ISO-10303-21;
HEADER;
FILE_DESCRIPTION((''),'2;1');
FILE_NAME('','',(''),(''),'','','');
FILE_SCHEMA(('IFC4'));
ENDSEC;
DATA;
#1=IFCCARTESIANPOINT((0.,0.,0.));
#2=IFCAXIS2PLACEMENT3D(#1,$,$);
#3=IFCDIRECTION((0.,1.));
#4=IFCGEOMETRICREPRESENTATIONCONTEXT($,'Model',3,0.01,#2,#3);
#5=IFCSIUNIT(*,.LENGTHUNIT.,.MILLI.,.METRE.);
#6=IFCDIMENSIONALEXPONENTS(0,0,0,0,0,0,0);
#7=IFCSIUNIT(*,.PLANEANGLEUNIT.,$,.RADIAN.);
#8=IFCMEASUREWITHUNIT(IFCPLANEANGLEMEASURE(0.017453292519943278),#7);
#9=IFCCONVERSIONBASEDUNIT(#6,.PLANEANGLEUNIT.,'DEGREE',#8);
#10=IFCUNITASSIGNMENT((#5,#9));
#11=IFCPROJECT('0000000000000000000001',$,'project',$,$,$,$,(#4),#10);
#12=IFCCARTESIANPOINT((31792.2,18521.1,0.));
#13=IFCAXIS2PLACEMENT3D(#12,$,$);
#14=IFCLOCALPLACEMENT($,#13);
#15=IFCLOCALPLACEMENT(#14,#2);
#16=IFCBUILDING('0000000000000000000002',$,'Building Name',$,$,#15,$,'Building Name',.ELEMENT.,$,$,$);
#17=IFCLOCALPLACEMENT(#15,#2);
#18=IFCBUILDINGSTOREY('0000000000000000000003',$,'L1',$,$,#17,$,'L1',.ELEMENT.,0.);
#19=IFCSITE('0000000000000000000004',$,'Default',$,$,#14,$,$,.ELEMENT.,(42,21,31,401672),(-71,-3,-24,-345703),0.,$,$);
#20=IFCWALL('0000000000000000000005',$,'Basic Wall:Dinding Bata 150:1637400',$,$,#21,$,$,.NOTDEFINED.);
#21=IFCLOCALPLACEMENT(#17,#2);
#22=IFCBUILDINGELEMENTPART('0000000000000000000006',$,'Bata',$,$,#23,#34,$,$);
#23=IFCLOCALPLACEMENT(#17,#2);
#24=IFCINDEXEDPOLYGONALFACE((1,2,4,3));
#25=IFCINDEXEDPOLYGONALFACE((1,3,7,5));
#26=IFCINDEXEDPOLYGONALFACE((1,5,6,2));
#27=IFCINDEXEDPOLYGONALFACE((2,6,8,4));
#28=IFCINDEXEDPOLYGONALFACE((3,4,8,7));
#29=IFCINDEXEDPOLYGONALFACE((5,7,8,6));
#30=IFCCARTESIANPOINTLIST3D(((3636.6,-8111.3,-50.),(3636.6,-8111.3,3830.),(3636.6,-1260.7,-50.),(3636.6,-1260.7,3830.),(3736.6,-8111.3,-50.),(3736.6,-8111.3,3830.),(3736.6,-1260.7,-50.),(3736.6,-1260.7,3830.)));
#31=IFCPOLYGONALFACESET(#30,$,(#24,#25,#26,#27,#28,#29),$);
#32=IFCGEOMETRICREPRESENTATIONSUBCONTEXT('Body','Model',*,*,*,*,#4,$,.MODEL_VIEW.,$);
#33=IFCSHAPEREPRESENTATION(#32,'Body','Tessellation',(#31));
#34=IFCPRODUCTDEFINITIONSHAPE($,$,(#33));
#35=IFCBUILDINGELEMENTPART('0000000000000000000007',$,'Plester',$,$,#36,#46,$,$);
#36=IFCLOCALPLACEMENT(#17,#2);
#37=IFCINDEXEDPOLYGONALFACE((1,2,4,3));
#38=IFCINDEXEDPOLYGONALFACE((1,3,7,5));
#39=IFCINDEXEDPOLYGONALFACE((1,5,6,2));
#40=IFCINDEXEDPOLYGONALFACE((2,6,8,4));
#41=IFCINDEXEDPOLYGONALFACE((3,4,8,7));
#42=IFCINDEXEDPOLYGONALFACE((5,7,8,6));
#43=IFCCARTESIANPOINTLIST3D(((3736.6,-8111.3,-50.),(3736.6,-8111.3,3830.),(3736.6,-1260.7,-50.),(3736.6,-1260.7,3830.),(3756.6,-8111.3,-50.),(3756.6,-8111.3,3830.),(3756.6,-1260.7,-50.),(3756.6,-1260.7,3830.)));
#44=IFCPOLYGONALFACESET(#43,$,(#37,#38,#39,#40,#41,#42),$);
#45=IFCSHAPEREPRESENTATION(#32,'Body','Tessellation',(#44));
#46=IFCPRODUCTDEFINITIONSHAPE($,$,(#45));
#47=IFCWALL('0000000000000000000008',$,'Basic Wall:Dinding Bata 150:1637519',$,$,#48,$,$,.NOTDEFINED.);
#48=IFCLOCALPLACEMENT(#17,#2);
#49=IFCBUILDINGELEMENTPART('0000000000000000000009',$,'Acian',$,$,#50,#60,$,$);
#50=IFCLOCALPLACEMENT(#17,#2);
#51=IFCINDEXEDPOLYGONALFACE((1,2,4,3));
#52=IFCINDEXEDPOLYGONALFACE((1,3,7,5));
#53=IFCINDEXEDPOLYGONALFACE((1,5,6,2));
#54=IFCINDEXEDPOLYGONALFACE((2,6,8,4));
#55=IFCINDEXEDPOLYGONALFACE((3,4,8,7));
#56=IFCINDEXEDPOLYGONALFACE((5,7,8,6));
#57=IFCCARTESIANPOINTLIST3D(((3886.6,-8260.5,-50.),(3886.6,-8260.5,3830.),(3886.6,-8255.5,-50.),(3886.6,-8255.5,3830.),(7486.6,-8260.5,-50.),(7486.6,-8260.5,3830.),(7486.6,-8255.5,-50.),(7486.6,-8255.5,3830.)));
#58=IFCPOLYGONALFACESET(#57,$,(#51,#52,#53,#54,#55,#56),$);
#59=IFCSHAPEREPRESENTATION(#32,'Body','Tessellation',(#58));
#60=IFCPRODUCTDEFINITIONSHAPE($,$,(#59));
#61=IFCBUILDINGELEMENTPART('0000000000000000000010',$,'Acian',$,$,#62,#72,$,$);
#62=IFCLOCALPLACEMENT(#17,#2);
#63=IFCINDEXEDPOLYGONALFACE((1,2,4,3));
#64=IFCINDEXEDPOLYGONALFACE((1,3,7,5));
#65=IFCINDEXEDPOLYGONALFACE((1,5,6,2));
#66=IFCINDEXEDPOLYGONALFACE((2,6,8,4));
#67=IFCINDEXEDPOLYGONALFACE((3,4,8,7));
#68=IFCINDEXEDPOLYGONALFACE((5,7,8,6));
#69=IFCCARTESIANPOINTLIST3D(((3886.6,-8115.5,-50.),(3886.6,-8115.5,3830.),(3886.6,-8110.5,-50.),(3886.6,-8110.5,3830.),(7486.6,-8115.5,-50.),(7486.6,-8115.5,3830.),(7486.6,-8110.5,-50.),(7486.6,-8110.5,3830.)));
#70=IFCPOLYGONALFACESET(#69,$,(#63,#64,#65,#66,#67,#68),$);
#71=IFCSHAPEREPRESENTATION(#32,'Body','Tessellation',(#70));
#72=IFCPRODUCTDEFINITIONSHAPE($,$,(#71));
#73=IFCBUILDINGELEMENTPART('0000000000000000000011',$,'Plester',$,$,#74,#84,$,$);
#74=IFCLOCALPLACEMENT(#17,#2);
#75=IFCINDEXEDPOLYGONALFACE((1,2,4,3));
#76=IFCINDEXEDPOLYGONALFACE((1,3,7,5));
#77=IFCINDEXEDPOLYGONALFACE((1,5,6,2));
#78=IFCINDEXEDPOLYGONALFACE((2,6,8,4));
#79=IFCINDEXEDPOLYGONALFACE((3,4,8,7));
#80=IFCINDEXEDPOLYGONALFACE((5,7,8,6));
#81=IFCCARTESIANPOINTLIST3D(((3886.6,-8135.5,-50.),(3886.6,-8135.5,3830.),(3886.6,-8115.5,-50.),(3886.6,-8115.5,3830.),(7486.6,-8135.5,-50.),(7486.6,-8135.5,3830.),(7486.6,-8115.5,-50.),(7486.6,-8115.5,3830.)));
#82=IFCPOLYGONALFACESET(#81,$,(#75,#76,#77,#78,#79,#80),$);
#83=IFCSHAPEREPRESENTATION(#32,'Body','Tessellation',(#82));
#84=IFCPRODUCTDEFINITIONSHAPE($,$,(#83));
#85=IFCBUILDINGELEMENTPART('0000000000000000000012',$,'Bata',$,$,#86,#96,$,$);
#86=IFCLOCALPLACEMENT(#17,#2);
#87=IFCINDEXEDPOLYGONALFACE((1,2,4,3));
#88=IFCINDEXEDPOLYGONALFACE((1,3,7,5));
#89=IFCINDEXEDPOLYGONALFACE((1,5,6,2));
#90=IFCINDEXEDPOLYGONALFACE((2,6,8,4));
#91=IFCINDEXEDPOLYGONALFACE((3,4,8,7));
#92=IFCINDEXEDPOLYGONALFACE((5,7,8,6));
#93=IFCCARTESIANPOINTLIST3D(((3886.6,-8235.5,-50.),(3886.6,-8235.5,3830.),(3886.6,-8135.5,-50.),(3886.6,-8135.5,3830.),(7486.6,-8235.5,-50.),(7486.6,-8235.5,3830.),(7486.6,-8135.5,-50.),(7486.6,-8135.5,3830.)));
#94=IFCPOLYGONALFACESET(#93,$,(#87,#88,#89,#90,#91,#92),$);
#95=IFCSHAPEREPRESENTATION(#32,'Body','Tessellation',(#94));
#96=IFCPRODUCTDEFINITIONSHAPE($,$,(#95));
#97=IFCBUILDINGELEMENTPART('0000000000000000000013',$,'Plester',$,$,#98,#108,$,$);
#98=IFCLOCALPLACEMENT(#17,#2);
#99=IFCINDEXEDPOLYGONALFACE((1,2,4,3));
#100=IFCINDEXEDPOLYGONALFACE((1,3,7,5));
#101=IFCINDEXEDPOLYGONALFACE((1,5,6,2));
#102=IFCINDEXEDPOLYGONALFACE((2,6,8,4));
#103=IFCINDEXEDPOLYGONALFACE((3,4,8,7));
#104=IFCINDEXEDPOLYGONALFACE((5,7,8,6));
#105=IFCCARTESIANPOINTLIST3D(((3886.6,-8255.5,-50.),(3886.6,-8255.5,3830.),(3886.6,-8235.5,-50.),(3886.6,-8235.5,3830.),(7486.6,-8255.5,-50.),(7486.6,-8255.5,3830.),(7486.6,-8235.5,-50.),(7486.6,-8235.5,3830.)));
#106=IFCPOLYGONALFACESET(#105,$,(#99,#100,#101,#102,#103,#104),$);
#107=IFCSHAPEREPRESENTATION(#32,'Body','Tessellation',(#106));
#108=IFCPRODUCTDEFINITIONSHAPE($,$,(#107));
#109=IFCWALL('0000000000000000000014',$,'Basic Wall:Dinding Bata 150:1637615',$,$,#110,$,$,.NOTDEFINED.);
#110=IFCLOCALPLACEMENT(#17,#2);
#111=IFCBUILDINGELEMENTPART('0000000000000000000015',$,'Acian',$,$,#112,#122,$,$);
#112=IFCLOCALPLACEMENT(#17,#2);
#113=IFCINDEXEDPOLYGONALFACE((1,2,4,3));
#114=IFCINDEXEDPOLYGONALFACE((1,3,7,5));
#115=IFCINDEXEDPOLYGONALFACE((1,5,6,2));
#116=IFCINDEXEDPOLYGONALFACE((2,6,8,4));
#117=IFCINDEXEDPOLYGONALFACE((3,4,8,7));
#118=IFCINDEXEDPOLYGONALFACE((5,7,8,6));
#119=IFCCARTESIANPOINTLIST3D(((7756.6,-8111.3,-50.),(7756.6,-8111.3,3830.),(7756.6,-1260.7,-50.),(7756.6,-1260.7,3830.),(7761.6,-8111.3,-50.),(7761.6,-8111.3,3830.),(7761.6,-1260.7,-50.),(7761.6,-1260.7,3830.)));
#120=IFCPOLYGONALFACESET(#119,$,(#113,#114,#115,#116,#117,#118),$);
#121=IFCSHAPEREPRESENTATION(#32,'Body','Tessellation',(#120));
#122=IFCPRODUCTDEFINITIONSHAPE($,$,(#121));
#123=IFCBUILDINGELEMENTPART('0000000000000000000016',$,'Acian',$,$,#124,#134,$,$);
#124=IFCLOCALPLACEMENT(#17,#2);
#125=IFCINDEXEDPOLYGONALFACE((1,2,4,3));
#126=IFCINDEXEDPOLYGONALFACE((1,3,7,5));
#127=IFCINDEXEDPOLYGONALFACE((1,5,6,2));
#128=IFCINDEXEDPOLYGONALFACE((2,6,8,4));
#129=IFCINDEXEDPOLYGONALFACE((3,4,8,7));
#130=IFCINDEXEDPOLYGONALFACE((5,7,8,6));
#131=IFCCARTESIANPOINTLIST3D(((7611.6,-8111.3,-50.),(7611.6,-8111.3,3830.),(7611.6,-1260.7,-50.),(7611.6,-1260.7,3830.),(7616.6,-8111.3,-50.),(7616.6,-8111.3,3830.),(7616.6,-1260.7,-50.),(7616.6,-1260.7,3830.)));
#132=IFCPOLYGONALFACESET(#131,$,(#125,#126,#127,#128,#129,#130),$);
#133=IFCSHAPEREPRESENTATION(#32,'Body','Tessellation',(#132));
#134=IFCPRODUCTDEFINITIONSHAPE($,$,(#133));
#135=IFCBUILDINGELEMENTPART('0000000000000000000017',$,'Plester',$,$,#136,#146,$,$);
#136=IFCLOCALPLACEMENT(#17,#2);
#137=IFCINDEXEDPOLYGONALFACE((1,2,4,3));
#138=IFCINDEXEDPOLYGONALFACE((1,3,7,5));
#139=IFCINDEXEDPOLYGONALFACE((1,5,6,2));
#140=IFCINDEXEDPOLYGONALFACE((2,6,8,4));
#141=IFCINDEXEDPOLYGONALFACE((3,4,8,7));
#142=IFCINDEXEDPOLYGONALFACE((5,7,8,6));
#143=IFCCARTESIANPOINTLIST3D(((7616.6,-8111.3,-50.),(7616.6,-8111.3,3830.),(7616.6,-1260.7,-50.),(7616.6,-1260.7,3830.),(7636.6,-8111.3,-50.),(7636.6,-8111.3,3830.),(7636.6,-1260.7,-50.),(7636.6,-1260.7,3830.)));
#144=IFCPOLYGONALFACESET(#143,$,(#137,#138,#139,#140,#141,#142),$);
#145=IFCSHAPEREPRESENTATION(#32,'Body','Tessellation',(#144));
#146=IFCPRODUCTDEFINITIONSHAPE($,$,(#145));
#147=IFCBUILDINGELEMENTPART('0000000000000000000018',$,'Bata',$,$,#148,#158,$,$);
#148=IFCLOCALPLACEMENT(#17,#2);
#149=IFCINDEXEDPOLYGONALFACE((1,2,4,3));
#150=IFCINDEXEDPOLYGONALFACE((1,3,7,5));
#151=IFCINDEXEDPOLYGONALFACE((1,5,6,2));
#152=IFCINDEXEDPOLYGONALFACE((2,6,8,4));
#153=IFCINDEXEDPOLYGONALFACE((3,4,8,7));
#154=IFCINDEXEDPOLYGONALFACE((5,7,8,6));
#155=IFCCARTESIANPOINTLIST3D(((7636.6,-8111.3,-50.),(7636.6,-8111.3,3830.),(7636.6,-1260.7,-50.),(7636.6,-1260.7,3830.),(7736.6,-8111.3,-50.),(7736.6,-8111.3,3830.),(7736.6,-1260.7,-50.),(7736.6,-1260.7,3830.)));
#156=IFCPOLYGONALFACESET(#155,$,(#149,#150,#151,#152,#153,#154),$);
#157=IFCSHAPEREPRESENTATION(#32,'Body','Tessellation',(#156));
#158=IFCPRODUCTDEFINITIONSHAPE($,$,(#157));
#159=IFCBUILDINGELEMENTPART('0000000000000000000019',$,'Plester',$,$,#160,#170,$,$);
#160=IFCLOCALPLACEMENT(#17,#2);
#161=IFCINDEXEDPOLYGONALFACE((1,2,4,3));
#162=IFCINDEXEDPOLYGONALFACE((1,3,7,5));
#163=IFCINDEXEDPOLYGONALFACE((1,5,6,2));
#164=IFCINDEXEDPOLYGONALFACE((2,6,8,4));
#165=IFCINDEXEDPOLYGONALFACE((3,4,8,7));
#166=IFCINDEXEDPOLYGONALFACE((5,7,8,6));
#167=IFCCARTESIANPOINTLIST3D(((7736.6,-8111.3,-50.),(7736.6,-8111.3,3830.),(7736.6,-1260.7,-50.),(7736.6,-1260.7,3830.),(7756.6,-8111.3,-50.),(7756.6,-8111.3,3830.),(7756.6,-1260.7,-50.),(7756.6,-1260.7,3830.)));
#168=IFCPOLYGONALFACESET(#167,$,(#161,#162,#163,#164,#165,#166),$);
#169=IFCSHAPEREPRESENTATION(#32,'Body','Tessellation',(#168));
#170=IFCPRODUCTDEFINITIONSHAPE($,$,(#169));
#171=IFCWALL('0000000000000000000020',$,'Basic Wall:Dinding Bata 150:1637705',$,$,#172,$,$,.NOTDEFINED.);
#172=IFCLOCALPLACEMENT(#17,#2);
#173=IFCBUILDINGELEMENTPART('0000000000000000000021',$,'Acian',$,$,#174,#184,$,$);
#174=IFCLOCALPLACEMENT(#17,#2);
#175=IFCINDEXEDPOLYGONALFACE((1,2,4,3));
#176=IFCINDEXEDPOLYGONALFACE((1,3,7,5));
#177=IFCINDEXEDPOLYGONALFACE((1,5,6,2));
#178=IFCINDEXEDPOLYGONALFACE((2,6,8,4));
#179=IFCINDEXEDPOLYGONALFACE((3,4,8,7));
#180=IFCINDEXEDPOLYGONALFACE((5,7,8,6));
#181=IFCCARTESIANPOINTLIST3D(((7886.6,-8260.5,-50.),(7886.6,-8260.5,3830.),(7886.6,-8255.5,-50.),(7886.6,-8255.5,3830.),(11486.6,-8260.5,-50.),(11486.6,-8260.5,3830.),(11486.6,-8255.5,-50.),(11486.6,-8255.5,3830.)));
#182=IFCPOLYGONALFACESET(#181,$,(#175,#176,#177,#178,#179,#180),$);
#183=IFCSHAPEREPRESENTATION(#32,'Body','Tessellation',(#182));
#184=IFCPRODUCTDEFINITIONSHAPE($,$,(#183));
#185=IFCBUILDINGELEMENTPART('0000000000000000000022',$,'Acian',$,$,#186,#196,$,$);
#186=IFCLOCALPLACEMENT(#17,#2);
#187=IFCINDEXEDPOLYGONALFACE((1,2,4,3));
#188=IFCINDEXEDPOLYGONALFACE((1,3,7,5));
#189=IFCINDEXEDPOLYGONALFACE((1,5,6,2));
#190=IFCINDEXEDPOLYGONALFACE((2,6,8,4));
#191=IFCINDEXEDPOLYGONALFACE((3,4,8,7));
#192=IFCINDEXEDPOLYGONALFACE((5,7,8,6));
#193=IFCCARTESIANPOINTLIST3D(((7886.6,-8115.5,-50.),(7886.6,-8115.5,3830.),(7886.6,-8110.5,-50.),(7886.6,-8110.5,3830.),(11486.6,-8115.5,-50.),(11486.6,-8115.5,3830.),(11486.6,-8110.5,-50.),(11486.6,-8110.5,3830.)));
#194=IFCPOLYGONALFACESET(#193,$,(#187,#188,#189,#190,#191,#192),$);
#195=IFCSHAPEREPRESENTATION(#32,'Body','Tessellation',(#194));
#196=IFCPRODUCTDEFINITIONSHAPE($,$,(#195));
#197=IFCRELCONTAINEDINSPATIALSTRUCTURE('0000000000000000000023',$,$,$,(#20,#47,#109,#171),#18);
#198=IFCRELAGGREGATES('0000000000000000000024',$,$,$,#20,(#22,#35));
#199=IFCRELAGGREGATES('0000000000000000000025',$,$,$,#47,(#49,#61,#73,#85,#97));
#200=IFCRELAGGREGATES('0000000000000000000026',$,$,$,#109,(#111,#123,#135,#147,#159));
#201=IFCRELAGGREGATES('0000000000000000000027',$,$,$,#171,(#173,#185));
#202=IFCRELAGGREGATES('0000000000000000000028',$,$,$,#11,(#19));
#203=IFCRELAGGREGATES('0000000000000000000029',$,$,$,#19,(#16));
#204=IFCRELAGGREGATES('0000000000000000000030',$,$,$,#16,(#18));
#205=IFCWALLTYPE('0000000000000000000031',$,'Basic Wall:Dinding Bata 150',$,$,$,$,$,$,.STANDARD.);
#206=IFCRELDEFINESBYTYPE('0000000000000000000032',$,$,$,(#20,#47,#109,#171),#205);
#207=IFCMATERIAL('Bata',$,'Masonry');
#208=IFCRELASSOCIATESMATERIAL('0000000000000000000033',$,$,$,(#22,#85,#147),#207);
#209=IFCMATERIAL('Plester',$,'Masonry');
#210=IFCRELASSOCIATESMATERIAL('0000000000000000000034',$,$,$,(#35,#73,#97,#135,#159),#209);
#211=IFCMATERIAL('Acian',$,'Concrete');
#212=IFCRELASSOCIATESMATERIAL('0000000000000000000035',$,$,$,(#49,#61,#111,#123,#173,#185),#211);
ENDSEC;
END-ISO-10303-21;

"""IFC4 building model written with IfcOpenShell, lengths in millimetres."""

from ifc_helpers import new_model, entity, si_unit, converted_unit, direction, frame, origin, place, context, subcontext, project, spatial, indexed_curve, outline, extrude, material, type_object, element, aggregate, save


model = new_model("IFC4")

# Units and contexts
model_context = context("Model", 3, precision=0.01, world=origin(), true_north=direction((0.0, 1.0)))
body_context = subcontext(model_context, "Body", "Model", "MODEL_VIEW")
ifc_project = project(units=[si_unit("LENGTHUNIT", "METRE", prefix="MILLI"), converted_unit("PLANEANGLEUNIT", "DEGREE", entity("IfcPlaneAngleMeasure", 0.017453292519943278), si_unit("PLANEANGLEUNIT", "RADIAN"), dimensions=[0, 0, 0, 0, 0, 0, 0])], contexts=[model_context])

# Site, building, storey
site_placement = place(None, frame((31792.2, 18521.1, 0.0)))
site = spatial("IfcSite", under=ifc_project, at=site_placement, Name="Default", CompositionType="ELEMENT", RefLatitude=(42, 21, 31, 401672), RefLongitude=(-71, -3, -24, -345703), RefElevation=0.0)
building_placement = place(site_placement, origin())
building = spatial("IfcBuilding", under=site, at=building_placement, Name="Building Name", LongName="Building Name", CompositionType="ELEMENT")
storey_placement = place(building_placement, origin())
storey = spatial("IfcBuildingStorey", under=building, at=storey_placement, Name="L1", LongName="L1", CompositionType="ELEMENT", Elevation=0.0)

# Walls, building element parts
wall_type = type_object("IfcWallType", Name="Basic Wall:Dinding Bata 150", PredefinedType="STANDARD")
wall_1_placement = place(storey_placement, frame((3686.6, -8111.3, -50.0), z_axis=(0.0, 0.0, 1.0), x_axis=(0.0, 1.0, 0.0)))
wall_1 = element("IfcWall", 1, at=wall_1_placement, inside=storey, type_object=wall_type, Name="Basic Wall:Dinding Bata 150:1637400", PredefinedType="NOTDEFINED")
ifc_material_1 = material(Name="Bata", Category="Masonry")
building_element_part_1_placement = place(wall_1_placement, origin())
building_element_part_1 = element("IfcBuildingElementPart", 2, at=building_element_part_1_placement, material=ifc_material_1, Name="Bata", context=body_context, shape_type="SweptSolid", body=[
    extrude(outline(indexed_curve([(-3425.3, -50.0), (3425.3, -50.0), (3425.3, 50.0), (-3425.3, 50.0), (-3425.3, -50.0)], self_intersect=False)), frame((3425.3, 0.0, 0.0), z_axis=(0.0, 0.0, 1.0), x_axis=(-1.0, 0.0, 0.0)), (0.0, 0.0, 1.0), 3880.0),
])
ifc_material_2 = material(Name="Plester", Category="Masonry")
building_element_part_2_placement = place(wall_1_placement, origin())
building_element_part_2 = element("IfcBuildingElementPart", 3, at=building_element_part_2_placement, material=ifc_material_2, Name="Plester", context=body_context, shape_type="SweptSolid", body=[
    extrude(outline(indexed_curve([(-3425.3, -10.0), (3425.3, -10.0), (3425.3, 10.0), (-3425.3, 10.0), (-3425.3, -10.0)], self_intersect=False)), frame((3425.3, -60.0, 0.0), z_axis=(0.0, 0.0, 1.0), x_axis=(-1.0, 0.0, 0.0)), (0.0, 0.0, 1.0), 3880.0),
])
aggregate(wall_1, [building_element_part_1, building_element_part_2])
wall_2_placement = place(storey_placement, frame((3886.6, -8185.5, -50.0)))
wall_2 = element("IfcWall", 4, at=wall_2_placement, inside=storey, type_object=wall_type, Name="Basic Wall:Dinding Bata 150:1637519", PredefinedType="NOTDEFINED")
ifc_material_3 = material(Name="Acian", Category="Concrete")
building_element_part_3_placement = place(wall_2_placement, origin())
building_element_part_3 = element("IfcBuildingElementPart", 5, at=building_element_part_3_placement, material=ifc_material_3, Name="Acian", context=body_context, shape_type="SweptSolid", body=[
    extrude(outline(indexed_curve([(-2.5, -1800.0), (2.5, -1800.0), (2.5, 1800.0), (-2.5, 1800.0), (-2.5, -1800.0)], self_intersect=False)), frame((1800.0, -72.5, 0.0), z_axis=(0.0, 0.0, 1.0), x_axis=(0.0, -1.0, 0.0)), (0.0, 0.0, 1.0), 3880.0),
])
building_element_part_4_placement = place(wall_2_placement, origin())
building_element_part_4 = element("IfcBuildingElementPart", 6, at=building_element_part_4_placement, material=ifc_material_3, Name="Acian", context=body_context, shape_type="SweptSolid", body=[
    extrude(outline(indexed_curve([(-2.5, -1800.0), (2.5, -1800.0), (2.5, 1800.0), (-2.5, 1800.0), (-2.5, -1800.0)], self_intersect=False)), frame((1800.0, 72.5, 0.0), z_axis=(0.0, 0.0, 1.0), x_axis=(0.0, -1.0, 0.0)), (0.0, 0.0, 1.0), 3880.0),
])
building_element_part_5_placement = place(wall_2_placement, origin())
building_element_part_5 = element("IfcBuildingElementPart", 7, at=building_element_part_5_placement, material=ifc_material_2, Name="Plester", context=body_context, shape_type="SweptSolid", body=[
    extrude(outline(indexed_curve([(-10.0, -1800.0), (10.0, -1800.0), (10.0, 1800.0), (-10.0, 1800.0), (-10.0, -1800.0)], self_intersect=False)), frame((1800.0, 60.0, 0.0), z_axis=(0.0, 0.0, 1.0), x_axis=(0.0, -1.0, 0.0)), (0.0, 0.0, 1.0), 3880.0),
])
building_element_part_6_placement = place(wall_2_placement, origin())
building_element_part_6 = element("IfcBuildingElementPart", 8, at=building_element_part_6_placement, material=ifc_material_1, Name="Bata", context=body_context, shape_type="SweptSolid", body=[
    extrude(outline(indexed_curve([(-50.0, -1800.0), (50.0, -1800.0), (50.0, 1800.0), (-50.0, 1800.0), (-50.0, -1800.0)], self_intersect=False)), frame((1800.0, 0.0, 0.0), z_axis=(0.0, 0.0, 1.0), x_axis=(0.0, -1.0, 0.0)), (0.0, 0.0, 1.0), 3880.0),
])
building_element_part_7_placement = place(wall_2_placement, origin())
building_element_part_7 = element("IfcBuildingElementPart", 9, at=building_element_part_7_placement, material=ifc_material_2, Name="Plester", context=body_context, shape_type="SweptSolid", body=[
    extrude(outline(indexed_curve([(-10.0, -1800.0), (10.0, -1800.0), (10.0, 1800.0), (-10.0, 1800.0), (-10.0, -1800.0)], self_intersect=False)), frame((1800.0, -60.0, 0.0), z_axis=(0.0, 0.0, 1.0), x_axis=(0.0, -1.0, 0.0)), (0.0, 0.0, 1.0), 3880.0),
])
aggregate(wall_2, [building_element_part_3, building_element_part_4, building_element_part_5, building_element_part_6, building_element_part_7])
wall_3_placement = place(storey_placement, frame((7686.6, -8111.3, -50.0), z_axis=(0.0, 0.0, 1.0), x_axis=(0.0, 1.0, 0.0)))
wall_3 = element("IfcWall", 10, at=wall_3_placement, inside=storey, type_object=wall_type, Name="Basic Wall:Dinding Bata 150:1637615", PredefinedType="NOTDEFINED")
building_element_part_8_placement = place(wall_3_placement, origin())
building_element_part_8 = element("IfcBuildingElementPart", 11, at=building_element_part_8_placement, material=ifc_material_3, Name="Acian", context=body_context, shape_type="SweptSolid", body=[
    extrude(outline(indexed_curve([(-3425.3, -2.5), (3425.3, -2.5), (3425.3, 2.5), (-3425.3, 2.5), (-3425.3, -2.5)], self_intersect=False)), frame((3425.3, -72.5, 0.0), z_axis=(0.0, 0.0, 1.0), x_axis=(-1.0, 0.0, 0.0)), (0.0, 0.0, 1.0), 3880.0),
])
building_element_part_9_placement = place(wall_3_placement, origin())
building_element_part_9 = element("IfcBuildingElementPart", 12, at=building_element_part_9_placement, material=ifc_material_3, Name="Acian", context=body_context, shape_type="SweptSolid", body=[
    extrude(outline(indexed_curve([(-3425.3, -2.5), (3425.3, -2.5), (3425.3, 2.5), (-3425.3, 2.5), (-3425.3, -2.5)], self_intersect=False)), frame((3425.3, 72.5, 0.0), z_axis=(0.0, 0.0, 1.0), x_axis=(-1.0, 0.0, 0.0)), (0.0, 0.0, 1.0), 3880.0),
])
building_element_part_10_placement = place(wall_3_placement, origin())
building_element_part_10 = element("IfcBuildingElementPart", 13, at=building_element_part_10_placement, material=ifc_material_2, Name="Plester", context=body_context, shape_type="SweptSolid", body=[
    extrude(outline(indexed_curve([(-3425.3, -10.0), (3425.3, -10.0), (3425.3, 10.0), (-3425.3, 10.0), (-3425.3, -10.0)], self_intersect=False)), frame((3425.3, 60.0, 0.0), z_axis=(0.0, 0.0, 1.0), x_axis=(-1.0, 0.0, 0.0)), (0.0, 0.0, 1.0), 3880.0),
])
building_element_part_11_placement = place(wall_3_placement, origin())
building_element_part_11 = element("IfcBuildingElementPart", 14, at=building_element_part_11_placement, material=ifc_material_1, Name="Bata", context=body_context, shape_type="SweptSolid", body=[
    extrude(outline(indexed_curve([(-3425.3, -50.0), (3425.3, -50.0), (3425.3, 50.0), (-3425.3, 50.0), (-3425.3, -50.0)], self_intersect=False)), frame((3425.3, 0.0, 0.0), z_axis=(0.0, 0.0, 1.0), x_axis=(-1.0, 0.0, 0.0)), (0.0, 0.0, 1.0), 3880.0),
])
building_element_part_12_placement = place(wall_3_placement, origin())
building_element_part_12 = element("IfcBuildingElementPart", 15, at=building_element_part_12_placement, material=ifc_material_2, Name="Plester", context=body_context, shape_type="SweptSolid", body=[
    extrude(outline(indexed_curve([(-3425.3, -10.0), (3425.3, -10.0), (3425.3, 10.0), (-3425.3, 10.0), (-3425.3, -10.0)], self_intersect=False)), frame((3425.3, -60.0, 0.0), z_axis=(0.0, 0.0, 1.0), x_axis=(-1.0, 0.0, 0.0)), (0.0, 0.0, 1.0), 3880.0),
])
aggregate(wall_3, [building_element_part_8, building_element_part_9, building_element_part_10, building_element_part_11, building_element_part_12])
wall_4_placement = place(storey_placement, frame((7886.6, -8185.5, -50.0)))
wall_4 = element("IfcWall", 16, at=wall_4_placement, inside=storey, type_object=wall_type, Name="Basic Wall:Dinding Bata 150:1637705", PredefinedType="NOTDEFINED")
building_element_part_13_placement = place(wall_4_placement, origin())
building_element_part_13 = element("IfcBuildingElementPart", 17, at=building_element_part_13_placement, material=ifc_material_3, Name="Acian", context=body_context, shape_type="SweptSolid", body=[
    extrude(outline(indexed_curve([(-2.5, -1800.0), (2.5, -1800.0), (2.5, 1800.0), (-2.5, 1800.0), (-2.5, -1800.0)], self_intersect=False)), frame((1800.0, -72.5, 0.0), z_axis=(0.0, 0.0, 1.0), x_axis=(0.0, -1.0, 0.0)), (0.0, 0.0, 1.0), 3880.0),
])
building_element_part_14_placement = place(wall_4_placement, origin())
building_element_part_14 = element("IfcBuildingElementPart", 18, at=building_element_part_14_placement, material=ifc_material_3, Name="Acian", context=body_context, shape_type="SweptSolid", body=[
    extrude(outline(indexed_curve([(-2.5, -1800.0), (2.5, -1800.0), (2.5, 1800.0), (-2.5, 1800.0), (-2.5, -1800.0)], self_intersect=False)), frame((1800.0, 72.5, 0.0), z_axis=(0.0, 0.0, 1.0), x_axis=(0.0, -1.0, 0.0)), (0.0, 0.0, 1.0), 3880.0),
])
aggregate(wall_4, [building_element_part_13, building_element_part_14])

save(model, "model.ifc")
